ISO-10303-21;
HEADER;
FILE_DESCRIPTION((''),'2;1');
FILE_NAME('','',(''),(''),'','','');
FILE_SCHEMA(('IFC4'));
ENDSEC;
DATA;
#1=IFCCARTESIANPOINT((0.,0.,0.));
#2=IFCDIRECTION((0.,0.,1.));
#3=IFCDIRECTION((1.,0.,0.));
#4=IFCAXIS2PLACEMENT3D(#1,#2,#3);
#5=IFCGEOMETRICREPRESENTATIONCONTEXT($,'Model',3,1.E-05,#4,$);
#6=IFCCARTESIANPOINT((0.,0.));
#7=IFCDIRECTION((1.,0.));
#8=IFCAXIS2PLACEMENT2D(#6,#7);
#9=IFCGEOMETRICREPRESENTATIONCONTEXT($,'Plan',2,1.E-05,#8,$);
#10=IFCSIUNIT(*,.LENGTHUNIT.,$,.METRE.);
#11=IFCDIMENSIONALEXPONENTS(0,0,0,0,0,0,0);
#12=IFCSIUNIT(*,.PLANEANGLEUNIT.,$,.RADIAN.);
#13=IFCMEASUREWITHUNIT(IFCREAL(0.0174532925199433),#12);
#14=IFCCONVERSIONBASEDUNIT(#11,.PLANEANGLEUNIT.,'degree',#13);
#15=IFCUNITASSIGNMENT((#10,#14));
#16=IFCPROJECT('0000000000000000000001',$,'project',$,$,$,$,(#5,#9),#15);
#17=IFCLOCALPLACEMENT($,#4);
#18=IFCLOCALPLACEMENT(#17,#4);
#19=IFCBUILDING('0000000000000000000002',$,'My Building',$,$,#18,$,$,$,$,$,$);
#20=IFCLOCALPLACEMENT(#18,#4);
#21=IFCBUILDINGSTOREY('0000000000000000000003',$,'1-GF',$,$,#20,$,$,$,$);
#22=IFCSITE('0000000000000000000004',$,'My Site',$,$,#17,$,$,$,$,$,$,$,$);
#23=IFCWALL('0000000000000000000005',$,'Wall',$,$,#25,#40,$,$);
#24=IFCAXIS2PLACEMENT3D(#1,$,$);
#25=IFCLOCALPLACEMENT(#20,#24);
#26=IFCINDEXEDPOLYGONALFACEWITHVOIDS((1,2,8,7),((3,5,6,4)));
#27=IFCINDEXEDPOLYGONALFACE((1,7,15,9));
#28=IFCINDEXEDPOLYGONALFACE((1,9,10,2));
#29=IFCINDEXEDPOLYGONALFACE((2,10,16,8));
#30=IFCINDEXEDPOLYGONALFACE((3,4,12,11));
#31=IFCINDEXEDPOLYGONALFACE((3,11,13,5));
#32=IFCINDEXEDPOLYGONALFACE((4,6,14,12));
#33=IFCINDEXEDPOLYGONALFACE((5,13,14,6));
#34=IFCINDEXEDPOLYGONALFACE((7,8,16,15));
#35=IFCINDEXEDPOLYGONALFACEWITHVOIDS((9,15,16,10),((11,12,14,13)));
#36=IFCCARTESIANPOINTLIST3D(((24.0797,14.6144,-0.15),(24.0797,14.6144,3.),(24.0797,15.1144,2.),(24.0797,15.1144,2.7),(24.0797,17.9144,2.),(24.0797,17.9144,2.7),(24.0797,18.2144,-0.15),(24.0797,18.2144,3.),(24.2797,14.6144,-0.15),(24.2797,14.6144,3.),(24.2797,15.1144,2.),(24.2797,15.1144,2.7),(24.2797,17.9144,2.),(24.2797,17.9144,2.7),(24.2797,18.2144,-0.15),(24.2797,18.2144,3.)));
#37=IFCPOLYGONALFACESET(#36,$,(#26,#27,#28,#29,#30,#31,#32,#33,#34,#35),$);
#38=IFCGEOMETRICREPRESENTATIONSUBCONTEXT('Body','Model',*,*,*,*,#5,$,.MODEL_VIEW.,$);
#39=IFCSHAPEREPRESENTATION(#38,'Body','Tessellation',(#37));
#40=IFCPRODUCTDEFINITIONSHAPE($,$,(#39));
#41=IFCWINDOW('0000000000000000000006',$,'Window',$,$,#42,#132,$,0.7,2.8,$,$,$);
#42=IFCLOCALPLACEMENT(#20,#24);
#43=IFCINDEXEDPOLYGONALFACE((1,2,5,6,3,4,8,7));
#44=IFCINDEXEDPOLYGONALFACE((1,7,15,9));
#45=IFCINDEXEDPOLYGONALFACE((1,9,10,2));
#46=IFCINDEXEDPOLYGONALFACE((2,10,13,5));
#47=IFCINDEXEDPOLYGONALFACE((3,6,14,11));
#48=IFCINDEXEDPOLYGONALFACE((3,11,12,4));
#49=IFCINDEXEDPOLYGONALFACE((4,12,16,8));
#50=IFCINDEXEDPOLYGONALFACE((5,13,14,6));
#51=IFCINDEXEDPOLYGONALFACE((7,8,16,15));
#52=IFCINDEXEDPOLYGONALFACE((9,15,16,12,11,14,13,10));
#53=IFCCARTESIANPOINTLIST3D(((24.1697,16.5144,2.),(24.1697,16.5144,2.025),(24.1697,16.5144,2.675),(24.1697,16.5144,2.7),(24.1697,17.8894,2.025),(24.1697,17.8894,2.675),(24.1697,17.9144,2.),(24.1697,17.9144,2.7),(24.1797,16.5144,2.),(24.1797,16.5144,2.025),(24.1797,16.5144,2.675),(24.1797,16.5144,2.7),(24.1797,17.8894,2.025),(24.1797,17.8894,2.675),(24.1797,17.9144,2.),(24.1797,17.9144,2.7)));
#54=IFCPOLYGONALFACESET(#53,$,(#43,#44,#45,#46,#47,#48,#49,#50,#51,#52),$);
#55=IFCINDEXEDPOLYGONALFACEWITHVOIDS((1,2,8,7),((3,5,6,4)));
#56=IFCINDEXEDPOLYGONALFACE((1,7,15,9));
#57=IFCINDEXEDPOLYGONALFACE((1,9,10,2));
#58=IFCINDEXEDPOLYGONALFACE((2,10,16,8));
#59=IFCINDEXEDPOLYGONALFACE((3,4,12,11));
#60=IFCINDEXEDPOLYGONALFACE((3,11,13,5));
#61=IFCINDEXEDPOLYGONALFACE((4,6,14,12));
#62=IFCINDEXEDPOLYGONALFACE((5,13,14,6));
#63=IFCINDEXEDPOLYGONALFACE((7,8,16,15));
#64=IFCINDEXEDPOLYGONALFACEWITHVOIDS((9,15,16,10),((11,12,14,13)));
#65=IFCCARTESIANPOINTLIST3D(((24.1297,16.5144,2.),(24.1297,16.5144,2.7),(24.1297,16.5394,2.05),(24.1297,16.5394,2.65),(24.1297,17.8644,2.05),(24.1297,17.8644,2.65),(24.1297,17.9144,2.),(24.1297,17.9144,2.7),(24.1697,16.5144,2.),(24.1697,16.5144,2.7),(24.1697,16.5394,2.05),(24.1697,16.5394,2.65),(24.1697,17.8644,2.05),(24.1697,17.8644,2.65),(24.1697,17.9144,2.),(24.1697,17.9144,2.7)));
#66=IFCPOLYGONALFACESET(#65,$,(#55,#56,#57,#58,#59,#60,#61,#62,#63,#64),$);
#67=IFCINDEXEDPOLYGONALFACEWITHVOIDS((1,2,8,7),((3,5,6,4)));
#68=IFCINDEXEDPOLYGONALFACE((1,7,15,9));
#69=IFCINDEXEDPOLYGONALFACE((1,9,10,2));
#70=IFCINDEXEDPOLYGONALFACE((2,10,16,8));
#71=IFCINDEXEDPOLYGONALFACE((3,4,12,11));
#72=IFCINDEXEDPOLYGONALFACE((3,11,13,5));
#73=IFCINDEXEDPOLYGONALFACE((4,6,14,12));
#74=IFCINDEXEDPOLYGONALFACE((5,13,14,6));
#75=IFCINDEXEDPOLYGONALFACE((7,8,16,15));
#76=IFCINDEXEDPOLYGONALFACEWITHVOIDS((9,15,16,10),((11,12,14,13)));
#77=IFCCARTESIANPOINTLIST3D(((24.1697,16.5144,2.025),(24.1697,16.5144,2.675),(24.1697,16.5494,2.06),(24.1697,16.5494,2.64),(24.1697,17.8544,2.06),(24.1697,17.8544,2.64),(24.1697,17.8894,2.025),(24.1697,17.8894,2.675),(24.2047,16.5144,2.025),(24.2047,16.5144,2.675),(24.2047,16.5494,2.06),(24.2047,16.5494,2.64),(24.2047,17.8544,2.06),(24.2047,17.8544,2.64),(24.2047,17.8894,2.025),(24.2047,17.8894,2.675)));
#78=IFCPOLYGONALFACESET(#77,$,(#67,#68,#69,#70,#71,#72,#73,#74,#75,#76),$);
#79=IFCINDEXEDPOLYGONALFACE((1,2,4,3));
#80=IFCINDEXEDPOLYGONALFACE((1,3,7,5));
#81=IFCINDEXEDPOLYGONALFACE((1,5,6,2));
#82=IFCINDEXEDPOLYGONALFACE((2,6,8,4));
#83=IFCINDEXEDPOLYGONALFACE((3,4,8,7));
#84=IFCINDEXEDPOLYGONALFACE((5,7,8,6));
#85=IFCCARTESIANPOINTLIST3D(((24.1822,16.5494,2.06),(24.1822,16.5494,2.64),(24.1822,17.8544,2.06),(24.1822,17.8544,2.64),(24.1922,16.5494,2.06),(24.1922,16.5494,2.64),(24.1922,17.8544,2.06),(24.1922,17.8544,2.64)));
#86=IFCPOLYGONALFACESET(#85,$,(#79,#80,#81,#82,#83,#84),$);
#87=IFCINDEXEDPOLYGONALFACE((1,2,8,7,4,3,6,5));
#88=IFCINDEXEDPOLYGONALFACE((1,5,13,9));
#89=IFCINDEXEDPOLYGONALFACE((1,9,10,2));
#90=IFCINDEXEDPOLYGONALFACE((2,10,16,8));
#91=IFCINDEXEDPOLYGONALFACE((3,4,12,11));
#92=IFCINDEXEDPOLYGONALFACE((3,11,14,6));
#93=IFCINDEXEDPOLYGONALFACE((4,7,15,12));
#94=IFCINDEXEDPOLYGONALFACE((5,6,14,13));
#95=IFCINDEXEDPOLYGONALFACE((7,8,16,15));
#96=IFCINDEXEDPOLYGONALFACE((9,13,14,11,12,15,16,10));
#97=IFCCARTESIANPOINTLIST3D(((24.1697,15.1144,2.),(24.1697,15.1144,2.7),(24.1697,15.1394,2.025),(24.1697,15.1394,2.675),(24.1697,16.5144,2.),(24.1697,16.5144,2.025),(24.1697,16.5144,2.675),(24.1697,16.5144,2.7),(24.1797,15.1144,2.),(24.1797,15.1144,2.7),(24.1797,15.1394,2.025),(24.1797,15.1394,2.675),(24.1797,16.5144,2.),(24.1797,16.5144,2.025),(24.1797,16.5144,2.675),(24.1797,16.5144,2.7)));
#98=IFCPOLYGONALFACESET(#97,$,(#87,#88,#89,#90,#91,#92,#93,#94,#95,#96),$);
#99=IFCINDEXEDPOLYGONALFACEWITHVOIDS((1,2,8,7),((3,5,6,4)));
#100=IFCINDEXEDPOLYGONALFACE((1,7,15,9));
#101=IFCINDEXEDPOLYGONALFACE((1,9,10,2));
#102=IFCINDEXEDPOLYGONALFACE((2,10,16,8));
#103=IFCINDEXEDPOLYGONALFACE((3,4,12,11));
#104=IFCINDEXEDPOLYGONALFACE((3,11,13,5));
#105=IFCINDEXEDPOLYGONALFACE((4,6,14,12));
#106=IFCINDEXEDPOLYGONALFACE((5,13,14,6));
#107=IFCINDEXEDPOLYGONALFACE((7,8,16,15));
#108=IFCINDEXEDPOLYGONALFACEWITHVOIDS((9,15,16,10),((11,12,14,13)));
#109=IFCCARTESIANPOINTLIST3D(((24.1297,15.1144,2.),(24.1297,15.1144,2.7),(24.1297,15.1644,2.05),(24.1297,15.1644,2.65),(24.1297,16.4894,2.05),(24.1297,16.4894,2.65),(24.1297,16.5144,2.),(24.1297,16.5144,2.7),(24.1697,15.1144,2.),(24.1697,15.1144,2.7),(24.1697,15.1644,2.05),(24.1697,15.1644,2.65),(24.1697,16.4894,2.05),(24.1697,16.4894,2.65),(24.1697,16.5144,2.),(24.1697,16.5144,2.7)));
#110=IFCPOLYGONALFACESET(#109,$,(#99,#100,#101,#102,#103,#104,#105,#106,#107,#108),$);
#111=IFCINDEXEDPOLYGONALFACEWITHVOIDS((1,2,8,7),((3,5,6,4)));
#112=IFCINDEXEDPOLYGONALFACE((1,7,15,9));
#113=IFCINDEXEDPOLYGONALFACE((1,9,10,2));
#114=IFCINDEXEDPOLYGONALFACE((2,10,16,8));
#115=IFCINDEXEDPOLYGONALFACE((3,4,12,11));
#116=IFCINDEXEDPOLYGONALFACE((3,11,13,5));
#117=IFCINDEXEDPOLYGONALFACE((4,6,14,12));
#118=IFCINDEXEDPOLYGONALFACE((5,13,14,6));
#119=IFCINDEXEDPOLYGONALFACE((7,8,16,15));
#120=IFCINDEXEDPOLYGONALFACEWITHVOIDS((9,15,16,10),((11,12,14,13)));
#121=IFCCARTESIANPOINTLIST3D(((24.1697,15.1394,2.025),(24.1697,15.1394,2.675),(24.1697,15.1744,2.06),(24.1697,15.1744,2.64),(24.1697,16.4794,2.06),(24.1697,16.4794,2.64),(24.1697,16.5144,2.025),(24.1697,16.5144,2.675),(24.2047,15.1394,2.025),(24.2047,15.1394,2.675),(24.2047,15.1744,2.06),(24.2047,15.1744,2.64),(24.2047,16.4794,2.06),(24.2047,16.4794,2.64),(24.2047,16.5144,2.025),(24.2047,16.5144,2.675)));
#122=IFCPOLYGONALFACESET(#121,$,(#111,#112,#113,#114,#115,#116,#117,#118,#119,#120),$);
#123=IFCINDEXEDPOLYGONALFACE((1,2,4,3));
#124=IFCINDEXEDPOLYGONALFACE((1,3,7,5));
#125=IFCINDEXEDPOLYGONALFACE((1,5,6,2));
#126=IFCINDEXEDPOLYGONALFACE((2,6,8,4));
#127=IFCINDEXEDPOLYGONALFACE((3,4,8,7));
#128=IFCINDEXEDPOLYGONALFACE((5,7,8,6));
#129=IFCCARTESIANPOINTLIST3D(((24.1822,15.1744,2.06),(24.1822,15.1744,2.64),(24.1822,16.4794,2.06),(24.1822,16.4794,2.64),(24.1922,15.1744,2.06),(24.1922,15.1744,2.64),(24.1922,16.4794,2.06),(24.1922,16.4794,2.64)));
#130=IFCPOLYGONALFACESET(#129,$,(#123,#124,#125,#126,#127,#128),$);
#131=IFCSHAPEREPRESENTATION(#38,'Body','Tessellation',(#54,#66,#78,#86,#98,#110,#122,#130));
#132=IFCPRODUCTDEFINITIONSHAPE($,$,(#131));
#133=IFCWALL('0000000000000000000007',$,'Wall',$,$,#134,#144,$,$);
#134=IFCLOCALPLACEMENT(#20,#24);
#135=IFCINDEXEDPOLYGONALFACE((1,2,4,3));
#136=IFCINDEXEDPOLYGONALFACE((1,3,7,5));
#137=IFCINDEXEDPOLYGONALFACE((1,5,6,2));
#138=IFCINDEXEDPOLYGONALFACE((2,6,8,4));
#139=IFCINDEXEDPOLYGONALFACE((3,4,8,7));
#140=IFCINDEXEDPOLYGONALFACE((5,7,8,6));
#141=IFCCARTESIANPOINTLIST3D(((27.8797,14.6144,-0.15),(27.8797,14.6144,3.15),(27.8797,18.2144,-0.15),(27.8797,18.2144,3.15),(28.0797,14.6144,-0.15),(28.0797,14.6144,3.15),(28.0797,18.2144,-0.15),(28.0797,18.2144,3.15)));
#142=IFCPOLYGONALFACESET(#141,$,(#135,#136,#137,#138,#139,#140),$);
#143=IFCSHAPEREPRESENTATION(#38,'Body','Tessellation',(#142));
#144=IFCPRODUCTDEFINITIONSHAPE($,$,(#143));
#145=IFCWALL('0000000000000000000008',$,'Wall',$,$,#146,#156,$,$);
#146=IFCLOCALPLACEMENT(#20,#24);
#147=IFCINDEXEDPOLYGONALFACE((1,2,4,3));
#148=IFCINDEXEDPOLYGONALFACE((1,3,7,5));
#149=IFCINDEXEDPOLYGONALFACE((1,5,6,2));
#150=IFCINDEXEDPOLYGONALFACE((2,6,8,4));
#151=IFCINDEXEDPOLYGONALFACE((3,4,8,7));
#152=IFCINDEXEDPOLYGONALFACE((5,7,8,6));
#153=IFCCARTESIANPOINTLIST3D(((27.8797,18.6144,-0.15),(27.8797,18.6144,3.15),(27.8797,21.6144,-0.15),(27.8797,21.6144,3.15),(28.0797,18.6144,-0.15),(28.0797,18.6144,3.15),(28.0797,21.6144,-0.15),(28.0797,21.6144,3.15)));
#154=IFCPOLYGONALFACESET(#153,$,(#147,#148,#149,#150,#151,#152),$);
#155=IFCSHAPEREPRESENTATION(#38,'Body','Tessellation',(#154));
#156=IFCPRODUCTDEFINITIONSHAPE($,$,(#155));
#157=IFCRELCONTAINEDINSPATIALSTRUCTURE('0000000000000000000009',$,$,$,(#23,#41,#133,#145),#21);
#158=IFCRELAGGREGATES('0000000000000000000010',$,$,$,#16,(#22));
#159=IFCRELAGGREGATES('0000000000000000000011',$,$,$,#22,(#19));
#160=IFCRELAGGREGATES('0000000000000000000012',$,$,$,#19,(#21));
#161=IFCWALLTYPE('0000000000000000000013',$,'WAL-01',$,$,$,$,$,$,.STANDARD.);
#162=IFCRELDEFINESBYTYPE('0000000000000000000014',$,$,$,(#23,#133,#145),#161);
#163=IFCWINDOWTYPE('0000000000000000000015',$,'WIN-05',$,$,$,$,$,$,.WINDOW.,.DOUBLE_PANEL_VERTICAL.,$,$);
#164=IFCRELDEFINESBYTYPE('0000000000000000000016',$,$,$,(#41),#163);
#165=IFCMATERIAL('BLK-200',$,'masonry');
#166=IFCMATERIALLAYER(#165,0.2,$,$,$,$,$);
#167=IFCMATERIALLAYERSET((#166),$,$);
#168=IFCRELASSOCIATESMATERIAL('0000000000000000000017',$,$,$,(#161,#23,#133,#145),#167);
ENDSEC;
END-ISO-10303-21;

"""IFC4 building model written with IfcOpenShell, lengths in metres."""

from ifc_helpers import new_model, entity, si_unit, converted_unit, frame, origin_with_axes, origin_2d_with_axis, place, context, subcontext, project, spatial, line, indexed_curve, outline, extrude, shape, source, transform, mapped, material, layer, layer_set, layer_usage, type_object, type_shapes, element, fill, save


model = new_model("IFC4")

# Units and contexts
model_context = context("Model", 3, precision=1e-05, world=origin_with_axes())
plan_context = context("Plan", 2, precision=1e-05, world=origin_2d_with_axis())
body_context_1 = subcontext(model_context, "Body", "Model", "MODEL_VIEW")
body_context_2 = subcontext(plan_context, "Body", "Plan", "PLAN_VIEW")
ifc_project = project(units=[si_unit("LENGTHUNIT", "METRE"), converted_unit("PLANEANGLEUNIT", "degree", entity("IfcReal", 0.0174532925199433), si_unit("PLANEANGLEUNIT", "RADIAN"), dimensions=[0, 0, 0, 0, 0, 0, 0])], contexts=[model_context, plan_context])

# Site, building, storey
site_placement = place(None, origin_with_axes())
site = spatial("IfcSite", under=ifc_project, at=site_placement, Name="My Site")
building_placement = place(site_placement, origin_with_axes())
building = spatial("IfcBuilding", under=site, at=building_placement, Name="My Building")
storey_placement = place(building_placement, origin_with_axes())
storey = spatial("IfcBuildingStorey", under=building, at=storey_placement, Name="1-GF")

# Wall, opening, window
ifc_material_1 = material(Name="BLK-200", Category="masonry")
ifc_layer_1 = layer(ifc_material_1, 0.2)
ifc_layer_set_1 = layer_set([ifc_layer_1])
wall_type_1 = type_object("IfcWallType", Name="WAL-01", PredefinedType="STANDARD", material=ifc_layer_set_1)
shared_shape_1 = source(origin_with_axes(), body_context_1, "Body", "SweptSolid", [
    extrude(outline(indexed_curve([(0.0, 0.0), (2.8, 0.0), (2.8, 0.7), (0.0, 0.7)], segments=[line(1, 2, 3, 4, 1)])), frame((0.0, -0.6, 0.0), z_axis=(0.0, -1.0, 0.0), x_axis=(1.0, 0.0, 0.0)), (0.0, 0.0, -1.0), 1.2),
])
window_type_1 = type_object("IfcWindowType", Name="WIN-05", PartitioningType="DOUBLE_PANEL_VERTICAL", PredefinedType="WINDOW")
shared_shape_2 = source(origin_with_axes(), body_context_1, "Body", "SweptSolid", [
    extrude(outline(indexed_curve([(1.4, 0.0), (0.0, 0.0), (0.0, 0.7), (1.4, 0.7), (1.4, 0.675), (0.025, 0.675), (0.025, 0.025), (1.4, 0.025)], segments=[line(1, 2, 3, 4, 5, 6, 7, 8, 1)])), frame((0.0, 0.09, 0.0), z_axis=(0.0, -1.0, 0.0), x_axis=(1.0, 0.0, 0.0)), (0.0, 0.0, -1.0), 0.01),
    extrude(outline(indexed_curve([(0.0, 0.0), (1.4, 0.0), (1.4, 0.7), (0.0, 0.7)], segments=[line(1, 2, 3, 4, 1)]), holes=[indexed_curve([(0.05, 0.05), (1.375, 0.05), (1.375, 0.65), (0.05, 0.65)], segments=[line(1, 2, 3, 4, 1)])]), frame((0.0, 0.05, 0.0), z_axis=(0.0, -1.0, 0.0), x_axis=(1.0, 0.0, 0.0)), (0.0, 0.0, -1.0), 0.04),
    extrude(outline(indexed_curve([(0.0, 0.0), (1.375, 0.0), (1.375, 0.65), (0.0, 0.65)], segments=[line(1, 2, 3, 4, 1)]), holes=[indexed_curve([(0.035, 0.035), (1.34, 0.035), (1.34, 0.615), (0.035, 0.615)], segments=[line(1, 2, 3, 4, 1)])]), frame((0.025, 0.09, 0.025), z_axis=(0.0, -1.0, 0.0), x_axis=(1.0, 0.0, 0.0)), (0.0, 0.0, -1.0), 0.035),
    extrude(outline(indexed_curve([(0.035, 0.035), (1.34, 0.035), (1.34, 0.615), (0.035, 0.615)], segments=[line(1, 2, 3, 4, 1)])), frame((0.025, 0.1025, 0.025), z_axis=(0.0, -1.0, 0.0), x_axis=(1.0, 0.0, 0.0)), (0.0, 0.0, -1.0), 0.01),
    extrude(outline(indexed_curve([(0.0, 0.7), (1.4, 0.7), (1.4, 0.0), (0.0, 0.0), (0.0, 0.025), (1.375, 0.025), (1.375, 0.675), (0.0, 0.675)], segments=[line(1, 2, 3, 4, 5, 6, 7, 8, 1)])), frame((1.4, 0.09, 0.0), z_axis=(0.0, -1.0, 0.0), x_axis=(1.0, 0.0, 0.0)), (0.0, 0.0, -1.0), 0.01),
    extrude(outline(indexed_curve([(0.0, 0.0), (1.4, 0.0), (1.4, 0.7), (0.0, 0.7)], segments=[line(1, 2, 3, 4, 1)]), holes=[indexed_curve([(0.025, 0.05), (1.35, 0.05), (1.35, 0.65), (0.025, 0.65)], segments=[line(1, 2, 3, 4, 1)])]), frame((1.4, 0.05, 0.0), z_axis=(0.0, -1.0, 0.0), x_axis=(1.0, 0.0, 0.0)), (0.0, 0.0, -1.0), 0.04),
    extrude(outline(indexed_curve([(0.0, 0.0), (1.375, 0.0), (1.375, 0.65), (0.0, 0.65)], segments=[line(1, 2, 3, 4, 1)]), holes=[indexed_curve([(0.035, 0.035), (1.34, 0.035), (1.34, 0.615), (0.035, 0.615)], segments=[line(1, 2, 3, 4, 1)])]), frame((1.4, 0.09, 0.025), z_axis=(0.0, -1.0, 0.0), x_axis=(1.0, 0.0, 0.0)), (0.0, 0.0, -1.0), 0.035),
    extrude(outline(indexed_curve([(0.035, 0.035), (1.34, 0.035), (1.34, 0.615), (0.035, 0.615)], segments=[line(1, 2, 3, 4, 1)])), frame((1.4, 0.1025, 0.025), z_axis=(0.0, -1.0, 0.0), x_axis=(1.0, 0.0, 0.0)), (0.0, 0.0, -1.0), 0.01),
])
shared_shape_3 = source(origin_with_axes(), body_context_2, "Body", "Curve2D", [
    entity("IfcIndexedPolyCurve", entity("IfcCartesianPointList2D", [[0.05, 0.05], [1.375, 0.05]])),
    entity("IfcIndexedPolyCurve", entity("IfcCartesianPointList2D", [[0.0, 0.1], [0.025, 0.1], [0.025, 0.09], [0.05, 0.09], [0.05, 0.05], [0.0, 0.05]]), [entity("IfcLineIndex", [1, 2, 3, 4, 5, 6, 1])]),
    entity("IfcIndexedPolyCurve", entity("IfcCartesianPointList2D", [[1.4, 0.1], [1.4, 0.1], [1.4, 0.09], [1.375, 0.09], [1.375, 0.05], [1.4, 0.05]])),
    entity("IfcIndexedPolyCurve", entity("IfcCartesianPointList2D", [[0.025, 0.09], [0.06, 0.09], [0.06, 0.125], [0.025, 0.125]]), [entity("IfcLineIndex", [1, 2, 3, 4, 1])]),
    entity("IfcIndexedPolyCurve", entity("IfcCartesianPointList2D", [[1.4, 0.09], [1.365, 0.09], [1.365, 0.125], [1.4, 0.125]]), [entity("IfcLineIndex", [1, 2, 3, 4, 1])]),
    entity("IfcIndexedPolyCurve", entity("IfcCartesianPointList2D", [[0.06, 0.09], [1.365, 0.09]])),
    entity("IfcIndexedPolyCurve", entity("IfcCartesianPointList2D", [[0.06, 0.125], [1.365, 0.125]])),
    entity("IfcIndexedPolyCurve", entity("IfcCartesianPointList2D", [[0.06, 0.1075], [1.365, 0.1075]])),
    entity("IfcIndexedPolyCurve", entity("IfcCartesianPointList2D", [[1.425, 0.05], [2.75, 0.05]])),
    entity("IfcIndexedPolyCurve", entity("IfcCartesianPointList2D", [[1.4, 0.1], [1.4, 0.1], [1.4, 0.09], [1.425, 0.09], [1.425, 0.05], [1.4, 0.05]])),
    entity("IfcIndexedPolyCurve", entity("IfcCartesianPointList2D", [[2.8, 0.1], [2.775, 0.1], [2.775, 0.09], [2.75, 0.09], [2.75, 0.05], [2.8, 0.05]]), [entity("IfcLineIndex", [1, 2, 3, 4, 5, 6, 1])]),
    entity("IfcIndexedPolyCurve", entity("IfcCartesianPointList2D", [[1.4, 0.09], [1.435, 0.09], [1.435, 0.125], [1.4, 0.125]]), [entity("IfcLineIndex", [1, 2, 3, 4, 1])]),
    entity("IfcIndexedPolyCurve", entity("IfcCartesianPointList2D", [[2.775, 0.09], [2.74, 0.09], [2.74, 0.125], [2.775, 0.125]]), [entity("IfcLineIndex", [1, 2, 3, 4, 1])]),
    entity("IfcIndexedPolyCurve", entity("IfcCartesianPointList2D", [[1.435, 0.09], [2.74, 0.09]])),
    entity("IfcIndexedPolyCurve", entity("IfcCartesianPointList2D", [[1.435, 0.125], [2.74, 0.125]])),
    entity("IfcIndexedPolyCurve", entity("IfcCartesianPointList2D", [[1.435, 0.1075], [2.74, 0.1075]])),
])
type_shapes(window_type_1, [shared_shape_2, shared_shape_3])
ifc_layer_usage_1 = layer_usage(ifc_layer_set_1, "AXIS2", "POSITIVE", 0.0)
wall_1_placement = place(storey_placement, frame((24.0797, 18.2144, -0.15), z_axis=(0.0, 0.0, 1.0), x_axis=(-0.000001, -1.0, 0.0)))
wall_1 = element("IfcWall", 1, at=wall_1_placement, inside=storey, type_object=wall_type_1, material=ifc_layer_usage_1, Name="Wall", context=body_context_1, shape_type="SweptSolid", body=[
    extrude(outline(indexed_curve([(0.0, 0.0), (0.0, 0.2), (3.6, 0.2), (3.6, 0.0), (0.0, 0.0)], self_intersect=False)), origin_with_axes(), (0.0, 0.0, 1.0), 3.15),
])
opening_1_placement = place(wall_1_placement, frame((0.3, 0.0, 2.15), z_axis=(0.0, 0.0, 1.0), x_axis=(1.0, 0.0, 0.0)))
opening_1 = element("IfcOpeningElement", 2, at=opening_1_placement, cuts=wall_1, PredefinedType="OPENING", context=body_context_1, shape_type="MappedRepresentation", body=[
    mapped(shared_shape_1, transform((0.0, 0.0, 0.0), x_axis=(1.0, 0.0, 0.0), y_axis=(0.0, 1.0, 0.0), z_axis=(0.0, 0.0, 1.0), scale=1.0)),
])
window_1_placement = place(opening_1_placement, frame((0.0, 0.0, 0.0), z_axis=(0.0, 0.0, 1.0), x_axis=(1.0, 0.0, 0.0)))
window_1 = element("IfcWindow", 3, at=window_1_placement, inside=storey, type_object=window_type_1, Name="Window", OverallHeight=0.7, OverallWidth=2.8, shapes=[
    shape(body_context_1, "Body", "MappedRepresentation", [mapped(shared_shape_2, transform((0.0, 0.0, 0.0), x_axis=(1.0, 0.0, 0.0), y_axis=(0.0, 1.0, 0.0), z_axis=(0.0, 0.0, 1.0), scale=1.0))]),
    shape(body_context_2, "Body", "MappedRepresentation", [mapped(shared_shape_3, transform((0.0, 0.0, 0.0), x_axis=(1.0, 0.0, 0.0), y_axis=(0.0, 1.0, 0.0), z_axis=(0.0, 0.0, 1.0), scale=1.0))]),
])
fill(opening_1, window_1)

# Walls
ifc_layer_usage_2 = layer_usage(ifc_layer_set_1, "AXIS2", "POSITIVE", 0.0)
wall_2_placement = place(storey_placement, frame((27.8797, 18.2144, -0.15), z_axis=(0.0, 0.0, 1.0), x_axis=(-0.000001, -1.0, 0.0)))
element("IfcWall", 4, at=wall_2_placement, inside=storey, type_object=wall_type_1, material=ifc_layer_usage_2, Name="Wall", context=body_context_1, shape_type="SweptSolid", body=[
    extrude(outline(indexed_curve([(0.0, 0.0), (0.0, 0.2), (3.6, 0.2), (3.6, 0.0), (0.0, 0.0)], self_intersect=False)), origin_with_axes(), (0.0, 0.0, 1.0), 3.3),
])
ifc_layer_usage_3 = layer_usage(ifc_layer_set_1, "AXIS2", "POSITIVE", 0.0)
wall_3_placement = place(storey_placement, frame((27.8797, 21.6144, -0.15), z_axis=(0.0, 0.0, 1.0), x_axis=(-0.000001, -1.0, 0.0)))
element("IfcWall", 5, at=wall_3_placement, inside=storey, type_object=wall_type_1, material=ifc_layer_usage_3, Name="Wall", context=body_context_1, shape_type="SweptSolid", body=[
    extrude(outline(indexed_curve([(0.0, 0.0), (0.0, 0.2), (3.0, 0.2), (3.0, 0.0), (0.0, 0.0)], self_intersect=False)), origin_with_axes(), (0.0, 0.0, 1.0), 3.3),
])

save(model, "model.ifc")
